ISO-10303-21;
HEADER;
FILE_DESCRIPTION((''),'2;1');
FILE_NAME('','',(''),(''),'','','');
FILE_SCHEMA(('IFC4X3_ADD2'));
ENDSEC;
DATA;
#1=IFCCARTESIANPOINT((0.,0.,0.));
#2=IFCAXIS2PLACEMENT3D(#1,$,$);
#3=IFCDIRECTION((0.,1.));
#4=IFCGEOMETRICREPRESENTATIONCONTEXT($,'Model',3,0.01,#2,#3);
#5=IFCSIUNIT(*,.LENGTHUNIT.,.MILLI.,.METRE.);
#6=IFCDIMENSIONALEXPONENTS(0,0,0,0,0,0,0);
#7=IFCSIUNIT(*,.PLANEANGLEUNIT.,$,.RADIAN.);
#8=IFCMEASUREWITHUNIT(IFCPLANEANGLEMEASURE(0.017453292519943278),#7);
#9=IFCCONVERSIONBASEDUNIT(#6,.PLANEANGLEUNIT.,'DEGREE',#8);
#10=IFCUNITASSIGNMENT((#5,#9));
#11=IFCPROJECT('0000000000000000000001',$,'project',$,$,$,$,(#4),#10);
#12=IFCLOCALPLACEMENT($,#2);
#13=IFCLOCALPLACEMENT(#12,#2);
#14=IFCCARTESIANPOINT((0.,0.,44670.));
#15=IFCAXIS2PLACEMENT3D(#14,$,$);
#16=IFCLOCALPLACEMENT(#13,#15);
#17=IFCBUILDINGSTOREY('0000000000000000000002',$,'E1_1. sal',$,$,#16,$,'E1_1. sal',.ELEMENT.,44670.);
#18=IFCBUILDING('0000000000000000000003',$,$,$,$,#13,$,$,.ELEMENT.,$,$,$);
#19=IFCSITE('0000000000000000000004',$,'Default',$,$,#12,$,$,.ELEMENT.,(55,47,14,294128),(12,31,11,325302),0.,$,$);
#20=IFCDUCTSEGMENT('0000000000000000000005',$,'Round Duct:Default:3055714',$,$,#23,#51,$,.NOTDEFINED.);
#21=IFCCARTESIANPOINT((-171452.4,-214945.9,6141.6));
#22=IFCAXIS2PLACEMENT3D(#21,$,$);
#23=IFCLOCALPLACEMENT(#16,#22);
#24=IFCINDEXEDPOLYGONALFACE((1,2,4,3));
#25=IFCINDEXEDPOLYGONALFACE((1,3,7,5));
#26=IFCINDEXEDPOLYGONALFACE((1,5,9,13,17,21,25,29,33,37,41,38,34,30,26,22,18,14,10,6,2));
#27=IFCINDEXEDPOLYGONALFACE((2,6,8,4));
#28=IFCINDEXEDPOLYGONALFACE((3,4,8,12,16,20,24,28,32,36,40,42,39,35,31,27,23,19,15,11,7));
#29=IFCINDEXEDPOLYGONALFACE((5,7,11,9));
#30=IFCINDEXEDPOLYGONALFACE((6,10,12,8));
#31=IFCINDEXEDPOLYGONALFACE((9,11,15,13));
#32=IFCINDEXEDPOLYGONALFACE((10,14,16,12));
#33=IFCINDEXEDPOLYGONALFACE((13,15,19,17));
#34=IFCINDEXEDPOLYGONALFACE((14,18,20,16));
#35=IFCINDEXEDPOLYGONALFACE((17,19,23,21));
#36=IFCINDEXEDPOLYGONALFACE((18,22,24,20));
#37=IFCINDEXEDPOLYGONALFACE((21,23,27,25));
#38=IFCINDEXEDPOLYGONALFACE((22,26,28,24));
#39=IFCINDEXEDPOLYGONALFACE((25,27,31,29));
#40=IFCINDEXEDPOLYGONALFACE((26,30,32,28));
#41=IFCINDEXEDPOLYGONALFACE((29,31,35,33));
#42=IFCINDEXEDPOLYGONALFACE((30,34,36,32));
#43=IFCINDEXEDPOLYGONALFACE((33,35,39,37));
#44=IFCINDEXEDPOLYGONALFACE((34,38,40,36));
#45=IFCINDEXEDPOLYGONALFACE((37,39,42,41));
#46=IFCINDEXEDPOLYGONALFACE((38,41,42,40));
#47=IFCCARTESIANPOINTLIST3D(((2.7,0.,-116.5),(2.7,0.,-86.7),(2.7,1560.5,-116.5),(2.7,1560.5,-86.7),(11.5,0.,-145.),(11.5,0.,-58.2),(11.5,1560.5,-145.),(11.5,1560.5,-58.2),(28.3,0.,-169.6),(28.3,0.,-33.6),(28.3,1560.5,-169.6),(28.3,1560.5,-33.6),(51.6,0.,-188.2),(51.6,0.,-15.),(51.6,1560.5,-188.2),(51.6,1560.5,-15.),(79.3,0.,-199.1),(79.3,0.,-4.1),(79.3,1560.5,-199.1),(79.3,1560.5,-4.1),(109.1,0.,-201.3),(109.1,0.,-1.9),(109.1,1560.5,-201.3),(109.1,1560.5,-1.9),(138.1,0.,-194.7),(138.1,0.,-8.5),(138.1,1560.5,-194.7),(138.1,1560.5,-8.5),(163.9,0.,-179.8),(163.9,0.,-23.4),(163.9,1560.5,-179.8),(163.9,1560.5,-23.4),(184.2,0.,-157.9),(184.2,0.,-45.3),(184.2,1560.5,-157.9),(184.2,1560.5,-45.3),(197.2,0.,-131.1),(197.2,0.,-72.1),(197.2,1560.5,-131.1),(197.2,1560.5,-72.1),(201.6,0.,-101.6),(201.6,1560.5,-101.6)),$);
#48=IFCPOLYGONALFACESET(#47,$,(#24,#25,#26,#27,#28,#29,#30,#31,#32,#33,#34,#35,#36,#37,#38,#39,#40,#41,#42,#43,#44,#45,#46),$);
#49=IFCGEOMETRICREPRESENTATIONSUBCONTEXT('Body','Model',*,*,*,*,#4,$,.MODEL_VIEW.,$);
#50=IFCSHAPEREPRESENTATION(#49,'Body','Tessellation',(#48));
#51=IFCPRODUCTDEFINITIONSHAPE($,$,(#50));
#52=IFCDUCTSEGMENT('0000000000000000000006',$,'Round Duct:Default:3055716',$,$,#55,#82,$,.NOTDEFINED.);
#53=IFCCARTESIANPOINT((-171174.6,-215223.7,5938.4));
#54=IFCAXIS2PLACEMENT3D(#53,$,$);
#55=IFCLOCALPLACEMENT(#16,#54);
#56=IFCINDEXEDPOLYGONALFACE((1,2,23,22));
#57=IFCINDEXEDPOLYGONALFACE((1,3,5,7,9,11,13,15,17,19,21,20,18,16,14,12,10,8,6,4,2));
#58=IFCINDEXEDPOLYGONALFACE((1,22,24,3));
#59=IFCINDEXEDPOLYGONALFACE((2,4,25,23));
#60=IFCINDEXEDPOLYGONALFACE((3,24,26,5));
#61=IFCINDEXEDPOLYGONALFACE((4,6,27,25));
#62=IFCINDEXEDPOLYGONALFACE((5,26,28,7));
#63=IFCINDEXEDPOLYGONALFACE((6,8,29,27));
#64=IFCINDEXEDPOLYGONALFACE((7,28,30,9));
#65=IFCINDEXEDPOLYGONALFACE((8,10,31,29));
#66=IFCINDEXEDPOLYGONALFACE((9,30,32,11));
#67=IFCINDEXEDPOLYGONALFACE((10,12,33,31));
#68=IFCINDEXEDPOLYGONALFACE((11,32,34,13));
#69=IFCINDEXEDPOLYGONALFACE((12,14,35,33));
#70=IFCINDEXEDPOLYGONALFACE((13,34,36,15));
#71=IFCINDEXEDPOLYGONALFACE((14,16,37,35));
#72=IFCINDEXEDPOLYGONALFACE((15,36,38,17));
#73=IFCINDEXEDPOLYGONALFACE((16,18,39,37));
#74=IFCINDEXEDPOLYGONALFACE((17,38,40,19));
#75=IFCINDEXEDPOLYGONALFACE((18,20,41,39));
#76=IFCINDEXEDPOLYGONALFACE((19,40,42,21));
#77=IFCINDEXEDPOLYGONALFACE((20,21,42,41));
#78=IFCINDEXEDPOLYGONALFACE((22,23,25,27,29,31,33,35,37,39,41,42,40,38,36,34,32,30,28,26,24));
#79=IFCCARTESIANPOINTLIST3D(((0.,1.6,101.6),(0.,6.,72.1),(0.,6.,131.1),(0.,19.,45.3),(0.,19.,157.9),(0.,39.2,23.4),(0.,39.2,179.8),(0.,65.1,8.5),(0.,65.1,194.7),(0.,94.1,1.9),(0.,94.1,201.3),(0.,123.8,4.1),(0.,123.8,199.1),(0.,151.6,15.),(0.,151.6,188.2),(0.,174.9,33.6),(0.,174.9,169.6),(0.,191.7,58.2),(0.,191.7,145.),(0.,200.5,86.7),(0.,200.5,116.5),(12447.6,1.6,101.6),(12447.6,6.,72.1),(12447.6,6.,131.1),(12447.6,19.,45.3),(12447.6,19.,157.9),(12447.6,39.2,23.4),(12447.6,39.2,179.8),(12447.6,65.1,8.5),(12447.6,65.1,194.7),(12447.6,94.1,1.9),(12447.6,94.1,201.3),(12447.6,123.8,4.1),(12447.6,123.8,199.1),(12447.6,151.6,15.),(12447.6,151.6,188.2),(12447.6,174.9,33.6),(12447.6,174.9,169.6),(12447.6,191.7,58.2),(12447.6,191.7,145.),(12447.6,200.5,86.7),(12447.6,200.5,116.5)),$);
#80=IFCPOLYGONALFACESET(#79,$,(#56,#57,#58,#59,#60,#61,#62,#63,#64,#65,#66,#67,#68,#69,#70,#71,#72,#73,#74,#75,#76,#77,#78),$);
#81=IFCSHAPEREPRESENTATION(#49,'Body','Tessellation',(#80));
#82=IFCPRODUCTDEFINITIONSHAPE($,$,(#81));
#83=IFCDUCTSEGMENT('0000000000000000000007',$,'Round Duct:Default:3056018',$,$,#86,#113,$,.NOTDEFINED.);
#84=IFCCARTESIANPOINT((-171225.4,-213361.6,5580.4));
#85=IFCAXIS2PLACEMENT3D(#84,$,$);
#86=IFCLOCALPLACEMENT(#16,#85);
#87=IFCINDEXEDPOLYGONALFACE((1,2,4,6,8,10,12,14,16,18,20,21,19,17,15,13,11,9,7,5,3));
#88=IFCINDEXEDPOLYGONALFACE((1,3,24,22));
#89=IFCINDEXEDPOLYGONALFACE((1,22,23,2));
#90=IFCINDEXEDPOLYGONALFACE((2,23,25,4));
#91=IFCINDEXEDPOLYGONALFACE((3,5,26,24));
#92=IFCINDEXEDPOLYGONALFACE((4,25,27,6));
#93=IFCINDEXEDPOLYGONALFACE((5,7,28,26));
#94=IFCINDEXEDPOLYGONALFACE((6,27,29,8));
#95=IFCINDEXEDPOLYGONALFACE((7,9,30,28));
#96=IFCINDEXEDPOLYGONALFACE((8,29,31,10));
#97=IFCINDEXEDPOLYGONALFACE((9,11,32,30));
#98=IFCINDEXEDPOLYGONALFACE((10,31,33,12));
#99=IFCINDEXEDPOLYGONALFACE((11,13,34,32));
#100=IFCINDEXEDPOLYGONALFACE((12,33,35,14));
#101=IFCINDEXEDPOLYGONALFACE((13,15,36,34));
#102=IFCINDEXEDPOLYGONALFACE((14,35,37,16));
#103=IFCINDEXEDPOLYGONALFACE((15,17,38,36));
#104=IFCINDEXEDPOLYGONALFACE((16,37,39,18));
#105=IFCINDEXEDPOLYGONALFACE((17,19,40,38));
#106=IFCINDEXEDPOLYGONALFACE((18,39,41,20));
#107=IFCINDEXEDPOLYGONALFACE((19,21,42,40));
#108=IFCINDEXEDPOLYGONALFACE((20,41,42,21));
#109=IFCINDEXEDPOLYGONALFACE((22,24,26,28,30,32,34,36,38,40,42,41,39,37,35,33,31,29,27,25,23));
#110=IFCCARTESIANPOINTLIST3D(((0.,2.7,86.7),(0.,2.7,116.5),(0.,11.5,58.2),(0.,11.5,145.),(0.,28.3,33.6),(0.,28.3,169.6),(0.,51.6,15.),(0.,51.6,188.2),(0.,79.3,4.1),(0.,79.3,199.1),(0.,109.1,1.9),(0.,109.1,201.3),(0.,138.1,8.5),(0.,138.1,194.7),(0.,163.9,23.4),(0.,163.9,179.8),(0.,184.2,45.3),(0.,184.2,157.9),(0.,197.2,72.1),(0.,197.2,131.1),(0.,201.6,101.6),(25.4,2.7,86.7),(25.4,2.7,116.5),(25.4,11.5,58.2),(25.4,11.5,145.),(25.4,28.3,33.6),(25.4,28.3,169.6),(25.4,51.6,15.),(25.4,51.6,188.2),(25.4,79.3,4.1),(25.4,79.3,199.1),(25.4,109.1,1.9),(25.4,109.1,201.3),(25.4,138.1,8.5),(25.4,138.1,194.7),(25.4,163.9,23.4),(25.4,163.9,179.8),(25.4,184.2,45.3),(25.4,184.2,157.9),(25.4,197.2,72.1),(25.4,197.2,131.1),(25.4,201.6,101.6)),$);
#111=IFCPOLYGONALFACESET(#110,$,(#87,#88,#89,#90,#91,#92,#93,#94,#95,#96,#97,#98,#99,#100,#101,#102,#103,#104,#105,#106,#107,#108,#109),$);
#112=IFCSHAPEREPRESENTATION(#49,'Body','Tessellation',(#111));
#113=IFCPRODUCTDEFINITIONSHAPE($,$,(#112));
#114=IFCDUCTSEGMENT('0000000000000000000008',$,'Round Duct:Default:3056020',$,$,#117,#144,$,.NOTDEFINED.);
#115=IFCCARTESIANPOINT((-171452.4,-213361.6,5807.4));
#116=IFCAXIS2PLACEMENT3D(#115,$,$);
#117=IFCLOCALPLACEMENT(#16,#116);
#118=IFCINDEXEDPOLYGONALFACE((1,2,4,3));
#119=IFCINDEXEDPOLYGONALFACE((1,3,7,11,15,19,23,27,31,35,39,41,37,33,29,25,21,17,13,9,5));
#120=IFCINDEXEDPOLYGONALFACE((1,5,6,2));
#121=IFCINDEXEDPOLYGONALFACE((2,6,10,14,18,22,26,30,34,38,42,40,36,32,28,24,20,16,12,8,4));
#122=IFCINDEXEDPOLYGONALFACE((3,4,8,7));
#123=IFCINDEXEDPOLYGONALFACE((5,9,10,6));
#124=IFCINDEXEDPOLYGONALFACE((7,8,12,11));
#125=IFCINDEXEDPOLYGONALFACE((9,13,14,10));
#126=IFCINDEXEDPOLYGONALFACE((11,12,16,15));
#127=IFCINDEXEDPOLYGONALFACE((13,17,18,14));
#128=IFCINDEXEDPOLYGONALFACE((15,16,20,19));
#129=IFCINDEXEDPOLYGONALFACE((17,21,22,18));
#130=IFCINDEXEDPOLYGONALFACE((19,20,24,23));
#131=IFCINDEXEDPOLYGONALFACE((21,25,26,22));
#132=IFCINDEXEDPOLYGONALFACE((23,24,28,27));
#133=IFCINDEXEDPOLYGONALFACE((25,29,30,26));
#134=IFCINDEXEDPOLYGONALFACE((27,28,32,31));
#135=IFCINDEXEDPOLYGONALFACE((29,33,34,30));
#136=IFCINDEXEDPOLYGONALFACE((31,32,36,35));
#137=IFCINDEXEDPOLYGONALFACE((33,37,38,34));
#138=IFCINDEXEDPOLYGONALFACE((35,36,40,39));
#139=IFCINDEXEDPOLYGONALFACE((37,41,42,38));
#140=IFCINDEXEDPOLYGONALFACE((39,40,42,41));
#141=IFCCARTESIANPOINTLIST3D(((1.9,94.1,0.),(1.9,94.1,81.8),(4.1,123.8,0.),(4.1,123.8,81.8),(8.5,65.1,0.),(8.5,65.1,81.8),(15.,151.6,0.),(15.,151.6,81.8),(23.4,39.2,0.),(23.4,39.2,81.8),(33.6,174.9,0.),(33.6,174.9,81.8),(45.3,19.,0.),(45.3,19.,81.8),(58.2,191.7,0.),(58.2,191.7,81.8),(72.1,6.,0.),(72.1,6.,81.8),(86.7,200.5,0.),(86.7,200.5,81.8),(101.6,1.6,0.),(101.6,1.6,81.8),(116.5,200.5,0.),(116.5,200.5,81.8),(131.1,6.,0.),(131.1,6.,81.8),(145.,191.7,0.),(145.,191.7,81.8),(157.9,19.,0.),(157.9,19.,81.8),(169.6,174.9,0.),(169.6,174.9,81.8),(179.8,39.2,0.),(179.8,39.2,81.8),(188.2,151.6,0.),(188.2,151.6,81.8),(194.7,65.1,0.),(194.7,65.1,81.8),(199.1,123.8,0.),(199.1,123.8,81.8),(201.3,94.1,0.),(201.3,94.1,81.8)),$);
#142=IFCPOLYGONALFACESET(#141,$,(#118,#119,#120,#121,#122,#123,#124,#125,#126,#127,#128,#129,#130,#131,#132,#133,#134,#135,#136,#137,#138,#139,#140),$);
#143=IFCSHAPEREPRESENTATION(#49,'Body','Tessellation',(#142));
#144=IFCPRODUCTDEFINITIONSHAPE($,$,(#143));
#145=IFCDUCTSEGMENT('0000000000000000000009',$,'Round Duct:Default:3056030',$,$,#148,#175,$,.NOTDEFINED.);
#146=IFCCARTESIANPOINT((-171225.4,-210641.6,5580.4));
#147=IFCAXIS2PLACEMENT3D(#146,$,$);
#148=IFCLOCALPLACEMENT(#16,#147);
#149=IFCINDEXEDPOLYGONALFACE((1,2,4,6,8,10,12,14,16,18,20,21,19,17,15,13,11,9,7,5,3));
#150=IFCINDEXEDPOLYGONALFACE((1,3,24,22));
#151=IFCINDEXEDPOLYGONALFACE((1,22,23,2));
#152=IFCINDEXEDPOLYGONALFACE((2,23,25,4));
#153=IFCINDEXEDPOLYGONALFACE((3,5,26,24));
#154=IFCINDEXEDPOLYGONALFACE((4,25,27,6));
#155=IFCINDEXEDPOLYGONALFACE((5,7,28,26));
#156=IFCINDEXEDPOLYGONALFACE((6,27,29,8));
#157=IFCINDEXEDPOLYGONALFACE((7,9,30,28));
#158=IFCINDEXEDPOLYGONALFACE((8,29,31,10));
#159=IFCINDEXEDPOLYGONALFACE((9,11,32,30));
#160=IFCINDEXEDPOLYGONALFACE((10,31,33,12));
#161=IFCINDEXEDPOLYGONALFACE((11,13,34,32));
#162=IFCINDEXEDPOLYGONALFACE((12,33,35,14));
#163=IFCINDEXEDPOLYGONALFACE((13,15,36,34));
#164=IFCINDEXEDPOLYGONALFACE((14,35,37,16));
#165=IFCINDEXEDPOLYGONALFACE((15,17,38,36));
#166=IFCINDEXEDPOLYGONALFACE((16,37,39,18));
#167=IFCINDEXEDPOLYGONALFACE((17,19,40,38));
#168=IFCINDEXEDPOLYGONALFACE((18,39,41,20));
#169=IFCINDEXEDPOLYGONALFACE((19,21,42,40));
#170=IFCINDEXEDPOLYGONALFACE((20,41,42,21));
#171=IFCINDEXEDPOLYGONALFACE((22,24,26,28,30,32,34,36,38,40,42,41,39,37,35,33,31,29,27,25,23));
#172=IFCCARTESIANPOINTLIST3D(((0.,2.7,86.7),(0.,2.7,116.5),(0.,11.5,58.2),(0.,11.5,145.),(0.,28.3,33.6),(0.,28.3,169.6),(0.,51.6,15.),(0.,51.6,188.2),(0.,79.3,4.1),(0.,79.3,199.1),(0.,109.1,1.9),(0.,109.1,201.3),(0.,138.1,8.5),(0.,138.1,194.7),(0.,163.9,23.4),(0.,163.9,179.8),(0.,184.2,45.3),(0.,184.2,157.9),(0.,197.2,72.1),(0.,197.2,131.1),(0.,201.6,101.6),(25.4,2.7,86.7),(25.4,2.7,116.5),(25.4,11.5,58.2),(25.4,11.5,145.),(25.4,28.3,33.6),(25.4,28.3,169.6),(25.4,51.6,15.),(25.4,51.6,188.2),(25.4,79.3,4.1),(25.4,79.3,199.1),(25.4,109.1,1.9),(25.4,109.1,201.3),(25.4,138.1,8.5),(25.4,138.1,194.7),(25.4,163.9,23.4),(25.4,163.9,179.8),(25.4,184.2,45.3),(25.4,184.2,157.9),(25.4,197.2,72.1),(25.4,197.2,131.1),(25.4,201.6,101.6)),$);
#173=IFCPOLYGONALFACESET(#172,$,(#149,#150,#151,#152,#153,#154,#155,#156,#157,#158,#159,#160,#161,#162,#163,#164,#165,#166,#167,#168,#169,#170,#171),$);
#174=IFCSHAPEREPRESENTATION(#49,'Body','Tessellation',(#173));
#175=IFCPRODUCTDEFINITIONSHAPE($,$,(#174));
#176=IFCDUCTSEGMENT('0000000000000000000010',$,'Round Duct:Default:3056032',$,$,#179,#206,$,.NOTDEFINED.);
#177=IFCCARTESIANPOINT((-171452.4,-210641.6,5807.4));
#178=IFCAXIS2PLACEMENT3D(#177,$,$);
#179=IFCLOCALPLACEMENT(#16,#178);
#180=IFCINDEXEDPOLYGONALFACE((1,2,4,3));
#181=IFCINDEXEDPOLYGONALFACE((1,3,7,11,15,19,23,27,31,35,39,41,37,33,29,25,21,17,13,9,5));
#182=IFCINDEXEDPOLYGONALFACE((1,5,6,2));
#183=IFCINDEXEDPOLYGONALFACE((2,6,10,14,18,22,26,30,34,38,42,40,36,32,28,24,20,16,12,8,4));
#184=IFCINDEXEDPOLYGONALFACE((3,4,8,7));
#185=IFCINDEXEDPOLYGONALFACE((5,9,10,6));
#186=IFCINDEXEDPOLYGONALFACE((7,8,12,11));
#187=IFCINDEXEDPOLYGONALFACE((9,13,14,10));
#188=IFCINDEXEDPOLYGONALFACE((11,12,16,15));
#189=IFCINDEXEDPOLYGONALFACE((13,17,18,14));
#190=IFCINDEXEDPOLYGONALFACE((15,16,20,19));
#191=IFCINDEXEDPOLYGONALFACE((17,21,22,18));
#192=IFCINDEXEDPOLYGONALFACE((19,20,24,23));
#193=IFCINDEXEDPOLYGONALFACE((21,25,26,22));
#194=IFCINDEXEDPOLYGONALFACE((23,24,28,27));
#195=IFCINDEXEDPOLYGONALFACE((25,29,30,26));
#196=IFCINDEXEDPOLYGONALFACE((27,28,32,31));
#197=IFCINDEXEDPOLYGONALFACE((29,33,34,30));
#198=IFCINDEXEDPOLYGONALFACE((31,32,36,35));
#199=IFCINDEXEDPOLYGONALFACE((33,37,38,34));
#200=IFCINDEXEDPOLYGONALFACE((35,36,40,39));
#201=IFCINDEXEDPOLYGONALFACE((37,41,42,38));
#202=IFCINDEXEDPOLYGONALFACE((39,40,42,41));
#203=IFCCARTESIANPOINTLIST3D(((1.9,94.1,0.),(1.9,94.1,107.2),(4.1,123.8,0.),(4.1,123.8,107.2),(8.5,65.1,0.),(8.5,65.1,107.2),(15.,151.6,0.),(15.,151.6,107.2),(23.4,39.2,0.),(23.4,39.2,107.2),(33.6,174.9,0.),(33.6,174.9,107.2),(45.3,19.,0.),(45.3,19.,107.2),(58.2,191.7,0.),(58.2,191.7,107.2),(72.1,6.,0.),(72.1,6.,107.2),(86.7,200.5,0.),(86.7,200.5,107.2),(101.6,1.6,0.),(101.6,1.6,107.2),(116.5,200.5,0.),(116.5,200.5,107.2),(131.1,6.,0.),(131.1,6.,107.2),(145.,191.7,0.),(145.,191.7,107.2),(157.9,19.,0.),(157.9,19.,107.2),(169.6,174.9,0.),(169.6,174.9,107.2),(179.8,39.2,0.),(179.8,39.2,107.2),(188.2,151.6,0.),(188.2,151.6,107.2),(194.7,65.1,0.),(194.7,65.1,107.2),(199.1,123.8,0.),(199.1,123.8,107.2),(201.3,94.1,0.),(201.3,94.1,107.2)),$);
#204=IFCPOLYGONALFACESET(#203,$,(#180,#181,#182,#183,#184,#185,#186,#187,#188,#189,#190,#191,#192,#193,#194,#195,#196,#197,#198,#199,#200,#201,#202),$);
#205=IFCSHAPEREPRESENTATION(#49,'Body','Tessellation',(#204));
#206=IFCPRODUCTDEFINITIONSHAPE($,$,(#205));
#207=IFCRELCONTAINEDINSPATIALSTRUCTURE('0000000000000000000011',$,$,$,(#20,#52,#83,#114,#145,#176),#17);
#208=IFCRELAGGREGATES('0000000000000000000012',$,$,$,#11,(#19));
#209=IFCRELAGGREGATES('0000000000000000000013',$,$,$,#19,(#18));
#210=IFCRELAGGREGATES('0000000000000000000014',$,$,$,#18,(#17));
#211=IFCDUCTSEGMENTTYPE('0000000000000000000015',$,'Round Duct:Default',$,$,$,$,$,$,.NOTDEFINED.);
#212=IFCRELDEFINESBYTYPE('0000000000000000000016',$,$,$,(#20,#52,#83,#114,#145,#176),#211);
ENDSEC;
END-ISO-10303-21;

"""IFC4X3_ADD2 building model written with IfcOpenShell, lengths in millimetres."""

from ifc_helpers import new_model, entity, si_unit, converted_unit, direction, frame, frame_2d, origin, origin_2d_with_axis, place, context, subcontext, project, spatial, circle, extrude, type_object, element, save


model = new_model("IFC4X3_ADD2")

# Units and contexts
model_context = context("Model", 3, precision=0.01, world=origin(), true_north=direction((0.0, 1.0)))
body_context = subcontext(model_context, "Body", "Model", "MODEL_VIEW")
ifc_project = project(units=[si_unit("LENGTHUNIT", "METRE", prefix="MILLI"), converted_unit("PLANEANGLEUNIT", "DEGREE", entity("IfcPlaneAngleMeasure", 0.017453292519943278), si_unit("PLANEANGLEUNIT", "RADIAN"), dimensions=[0, 0, 0, 0, 0, 0, 0])], contexts=[model_context])

# Site, building, storey
site_placement = place(None, origin())
site = spatial("IfcSite", under=ifc_project, at=site_placement, Name="Default", CompositionType="ELEMENT", RefLatitude=(55, 47, 14, 294128), RefLongitude=(12, 31, 11, 325302), RefElevation=0.0)
building_placement = place(site_placement, origin())
building = spatial("IfcBuilding", under=site, at=building_placement, CompositionType="ELEMENT")
storey_placement = place(building_placement, frame((0.0, 0.0, 44670.0)))
storey = spatial("IfcBuildingStorey", under=building, at=storey_placement, Name="E1_1. sal", LongName="E1_1. sal", CompositionType="ELEMENT", Elevation=44670.0)

# Duct segments
duct_segment_type = type_object("IfcDuctSegmentType", Name="Round Duct:Default", PredefinedType="NOTDEFINED")
duct_segment_1_placement = place(storey_placement, frame((-171452.4, -214945.9, 6141.6)))
element("IfcDuctSegment", 1, at=duct_segment_1_placement, inside=storey, type_object=duct_segment_type, Name="Round Duct:Default:3055714", PredefinedType="NOTDEFINED", context=body_context, shape_type="SweptSolid", body=[
    extrude(circle(Radius=100.0, at=origin_2d_with_axis()), frame((101.6, 0.0, -101.6), z_axis=(0.0, 1.0, 0.0), x_axis=(1.0, 0.0, 0.0)), (0.0, 0.0, 1.0), 1560.5),
])
duct_segment_2_placement = place(storey_placement, frame((-171174.6, -215223.7, 5938.4)))
element("IfcDuctSegment", 2, at=duct_segment_2_placement, inside=storey, type_object=duct_segment_type, Name="Round Duct:Default:3055716", PredefinedType="NOTDEFINED", context=body_context, shape_type="SweptSolid", body=[
    extrude(circle(Radius=100.0, at=origin_2d_with_axis()), frame((0.0, 101.6, 101.6), z_axis=(1.0, 0.0, 0.0), x_axis=(0.0, -1.0, 0.0)), (0.0, 0.0, 1.0), 12447.6),
])
duct_segment_3_placement = place(storey_placement, frame((-171225.4, -213361.6, 5580.4)))
element("IfcDuctSegment", 3, at=duct_segment_3_placement, inside=storey, type_object=duct_segment_type, Name="Round Duct:Default:3056018", PredefinedType="NOTDEFINED", context=body_context, shape_type="SweptSolid", body=[
    extrude(circle(Radius=100.0, at=frame_2d((0.0, 0.0), x_axis=(1.0, 0.0))), frame((0.0, 101.6, 101.6), z_axis=(1.0, 0.0, 0.0), x_axis=(0.0, 1.0, 0.0)), (0.0, 0.0, 1.0), 25.4),
])
duct_segment_4_placement = place(storey_placement, frame((-171452.4, -213361.6, 5807.4)))
element("IfcDuctSegment", 4, at=duct_segment_4_placement, inside=storey, type_object=duct_segment_type, Name="Round Duct:Default:3056020", PredefinedType="NOTDEFINED", context=body_context, shape_type="SweptSolid", body=[
    extrude(circle(Radius=100.0, at=origin_2d_with_axis()), frame((101.6, 101.6, 0.0), z_axis=(0.0, 0.0, 1.0), x_axis=(0.0, -1.0, 0.0)), (0.0, 0.0, 1.0), 81.8),
])
duct_segment_5_placement = place(storey_placement, frame((-171225.4, -210641.6, 5580.4)))
element("IfcDuctSegment", 5, at=duct_segment_5_placement, inside=storey, type_object=duct_segment_type, Name="Round Duct:Default:3056030", PredefinedType="NOTDEFINED", context=body_context, shape_type="SweptSolid", body=[
    extrude(circle(Radius=100.0, at=frame_2d((0.0, 0.0), x_axis=(1.0, 0.0))), frame((0.0, 101.6, 101.6), z_axis=(1.0, 0.0, 0.0), x_axis=(0.0, 1.0, 0.0)), (0.0, 0.0, 1.0), 25.4),
])
duct_segment_6_placement = place(storey_placement, frame((-171452.4, -210641.6, 5807.4)))
element("IfcDuctSegment", 6, at=duct_segment_6_placement, inside=storey, type_object=duct_segment_type, Name="Round Duct:Default:3056032", PredefinedType="NOTDEFINED", context=body_context, shape_type="SweptSolid", body=[
    extrude(circle(Radius=100.0, at=frame_2d((0.0, 0.0), x_axis=(1.0, 0.0))), frame((101.6, 101.6, 0.0), z_axis=(0.0, 0.0, 1.0), x_axis=(0.0, -1.0, 0.0)), (0.0, 0.0, 1.0), 107.2),
])

save(model, "model.ifc")
